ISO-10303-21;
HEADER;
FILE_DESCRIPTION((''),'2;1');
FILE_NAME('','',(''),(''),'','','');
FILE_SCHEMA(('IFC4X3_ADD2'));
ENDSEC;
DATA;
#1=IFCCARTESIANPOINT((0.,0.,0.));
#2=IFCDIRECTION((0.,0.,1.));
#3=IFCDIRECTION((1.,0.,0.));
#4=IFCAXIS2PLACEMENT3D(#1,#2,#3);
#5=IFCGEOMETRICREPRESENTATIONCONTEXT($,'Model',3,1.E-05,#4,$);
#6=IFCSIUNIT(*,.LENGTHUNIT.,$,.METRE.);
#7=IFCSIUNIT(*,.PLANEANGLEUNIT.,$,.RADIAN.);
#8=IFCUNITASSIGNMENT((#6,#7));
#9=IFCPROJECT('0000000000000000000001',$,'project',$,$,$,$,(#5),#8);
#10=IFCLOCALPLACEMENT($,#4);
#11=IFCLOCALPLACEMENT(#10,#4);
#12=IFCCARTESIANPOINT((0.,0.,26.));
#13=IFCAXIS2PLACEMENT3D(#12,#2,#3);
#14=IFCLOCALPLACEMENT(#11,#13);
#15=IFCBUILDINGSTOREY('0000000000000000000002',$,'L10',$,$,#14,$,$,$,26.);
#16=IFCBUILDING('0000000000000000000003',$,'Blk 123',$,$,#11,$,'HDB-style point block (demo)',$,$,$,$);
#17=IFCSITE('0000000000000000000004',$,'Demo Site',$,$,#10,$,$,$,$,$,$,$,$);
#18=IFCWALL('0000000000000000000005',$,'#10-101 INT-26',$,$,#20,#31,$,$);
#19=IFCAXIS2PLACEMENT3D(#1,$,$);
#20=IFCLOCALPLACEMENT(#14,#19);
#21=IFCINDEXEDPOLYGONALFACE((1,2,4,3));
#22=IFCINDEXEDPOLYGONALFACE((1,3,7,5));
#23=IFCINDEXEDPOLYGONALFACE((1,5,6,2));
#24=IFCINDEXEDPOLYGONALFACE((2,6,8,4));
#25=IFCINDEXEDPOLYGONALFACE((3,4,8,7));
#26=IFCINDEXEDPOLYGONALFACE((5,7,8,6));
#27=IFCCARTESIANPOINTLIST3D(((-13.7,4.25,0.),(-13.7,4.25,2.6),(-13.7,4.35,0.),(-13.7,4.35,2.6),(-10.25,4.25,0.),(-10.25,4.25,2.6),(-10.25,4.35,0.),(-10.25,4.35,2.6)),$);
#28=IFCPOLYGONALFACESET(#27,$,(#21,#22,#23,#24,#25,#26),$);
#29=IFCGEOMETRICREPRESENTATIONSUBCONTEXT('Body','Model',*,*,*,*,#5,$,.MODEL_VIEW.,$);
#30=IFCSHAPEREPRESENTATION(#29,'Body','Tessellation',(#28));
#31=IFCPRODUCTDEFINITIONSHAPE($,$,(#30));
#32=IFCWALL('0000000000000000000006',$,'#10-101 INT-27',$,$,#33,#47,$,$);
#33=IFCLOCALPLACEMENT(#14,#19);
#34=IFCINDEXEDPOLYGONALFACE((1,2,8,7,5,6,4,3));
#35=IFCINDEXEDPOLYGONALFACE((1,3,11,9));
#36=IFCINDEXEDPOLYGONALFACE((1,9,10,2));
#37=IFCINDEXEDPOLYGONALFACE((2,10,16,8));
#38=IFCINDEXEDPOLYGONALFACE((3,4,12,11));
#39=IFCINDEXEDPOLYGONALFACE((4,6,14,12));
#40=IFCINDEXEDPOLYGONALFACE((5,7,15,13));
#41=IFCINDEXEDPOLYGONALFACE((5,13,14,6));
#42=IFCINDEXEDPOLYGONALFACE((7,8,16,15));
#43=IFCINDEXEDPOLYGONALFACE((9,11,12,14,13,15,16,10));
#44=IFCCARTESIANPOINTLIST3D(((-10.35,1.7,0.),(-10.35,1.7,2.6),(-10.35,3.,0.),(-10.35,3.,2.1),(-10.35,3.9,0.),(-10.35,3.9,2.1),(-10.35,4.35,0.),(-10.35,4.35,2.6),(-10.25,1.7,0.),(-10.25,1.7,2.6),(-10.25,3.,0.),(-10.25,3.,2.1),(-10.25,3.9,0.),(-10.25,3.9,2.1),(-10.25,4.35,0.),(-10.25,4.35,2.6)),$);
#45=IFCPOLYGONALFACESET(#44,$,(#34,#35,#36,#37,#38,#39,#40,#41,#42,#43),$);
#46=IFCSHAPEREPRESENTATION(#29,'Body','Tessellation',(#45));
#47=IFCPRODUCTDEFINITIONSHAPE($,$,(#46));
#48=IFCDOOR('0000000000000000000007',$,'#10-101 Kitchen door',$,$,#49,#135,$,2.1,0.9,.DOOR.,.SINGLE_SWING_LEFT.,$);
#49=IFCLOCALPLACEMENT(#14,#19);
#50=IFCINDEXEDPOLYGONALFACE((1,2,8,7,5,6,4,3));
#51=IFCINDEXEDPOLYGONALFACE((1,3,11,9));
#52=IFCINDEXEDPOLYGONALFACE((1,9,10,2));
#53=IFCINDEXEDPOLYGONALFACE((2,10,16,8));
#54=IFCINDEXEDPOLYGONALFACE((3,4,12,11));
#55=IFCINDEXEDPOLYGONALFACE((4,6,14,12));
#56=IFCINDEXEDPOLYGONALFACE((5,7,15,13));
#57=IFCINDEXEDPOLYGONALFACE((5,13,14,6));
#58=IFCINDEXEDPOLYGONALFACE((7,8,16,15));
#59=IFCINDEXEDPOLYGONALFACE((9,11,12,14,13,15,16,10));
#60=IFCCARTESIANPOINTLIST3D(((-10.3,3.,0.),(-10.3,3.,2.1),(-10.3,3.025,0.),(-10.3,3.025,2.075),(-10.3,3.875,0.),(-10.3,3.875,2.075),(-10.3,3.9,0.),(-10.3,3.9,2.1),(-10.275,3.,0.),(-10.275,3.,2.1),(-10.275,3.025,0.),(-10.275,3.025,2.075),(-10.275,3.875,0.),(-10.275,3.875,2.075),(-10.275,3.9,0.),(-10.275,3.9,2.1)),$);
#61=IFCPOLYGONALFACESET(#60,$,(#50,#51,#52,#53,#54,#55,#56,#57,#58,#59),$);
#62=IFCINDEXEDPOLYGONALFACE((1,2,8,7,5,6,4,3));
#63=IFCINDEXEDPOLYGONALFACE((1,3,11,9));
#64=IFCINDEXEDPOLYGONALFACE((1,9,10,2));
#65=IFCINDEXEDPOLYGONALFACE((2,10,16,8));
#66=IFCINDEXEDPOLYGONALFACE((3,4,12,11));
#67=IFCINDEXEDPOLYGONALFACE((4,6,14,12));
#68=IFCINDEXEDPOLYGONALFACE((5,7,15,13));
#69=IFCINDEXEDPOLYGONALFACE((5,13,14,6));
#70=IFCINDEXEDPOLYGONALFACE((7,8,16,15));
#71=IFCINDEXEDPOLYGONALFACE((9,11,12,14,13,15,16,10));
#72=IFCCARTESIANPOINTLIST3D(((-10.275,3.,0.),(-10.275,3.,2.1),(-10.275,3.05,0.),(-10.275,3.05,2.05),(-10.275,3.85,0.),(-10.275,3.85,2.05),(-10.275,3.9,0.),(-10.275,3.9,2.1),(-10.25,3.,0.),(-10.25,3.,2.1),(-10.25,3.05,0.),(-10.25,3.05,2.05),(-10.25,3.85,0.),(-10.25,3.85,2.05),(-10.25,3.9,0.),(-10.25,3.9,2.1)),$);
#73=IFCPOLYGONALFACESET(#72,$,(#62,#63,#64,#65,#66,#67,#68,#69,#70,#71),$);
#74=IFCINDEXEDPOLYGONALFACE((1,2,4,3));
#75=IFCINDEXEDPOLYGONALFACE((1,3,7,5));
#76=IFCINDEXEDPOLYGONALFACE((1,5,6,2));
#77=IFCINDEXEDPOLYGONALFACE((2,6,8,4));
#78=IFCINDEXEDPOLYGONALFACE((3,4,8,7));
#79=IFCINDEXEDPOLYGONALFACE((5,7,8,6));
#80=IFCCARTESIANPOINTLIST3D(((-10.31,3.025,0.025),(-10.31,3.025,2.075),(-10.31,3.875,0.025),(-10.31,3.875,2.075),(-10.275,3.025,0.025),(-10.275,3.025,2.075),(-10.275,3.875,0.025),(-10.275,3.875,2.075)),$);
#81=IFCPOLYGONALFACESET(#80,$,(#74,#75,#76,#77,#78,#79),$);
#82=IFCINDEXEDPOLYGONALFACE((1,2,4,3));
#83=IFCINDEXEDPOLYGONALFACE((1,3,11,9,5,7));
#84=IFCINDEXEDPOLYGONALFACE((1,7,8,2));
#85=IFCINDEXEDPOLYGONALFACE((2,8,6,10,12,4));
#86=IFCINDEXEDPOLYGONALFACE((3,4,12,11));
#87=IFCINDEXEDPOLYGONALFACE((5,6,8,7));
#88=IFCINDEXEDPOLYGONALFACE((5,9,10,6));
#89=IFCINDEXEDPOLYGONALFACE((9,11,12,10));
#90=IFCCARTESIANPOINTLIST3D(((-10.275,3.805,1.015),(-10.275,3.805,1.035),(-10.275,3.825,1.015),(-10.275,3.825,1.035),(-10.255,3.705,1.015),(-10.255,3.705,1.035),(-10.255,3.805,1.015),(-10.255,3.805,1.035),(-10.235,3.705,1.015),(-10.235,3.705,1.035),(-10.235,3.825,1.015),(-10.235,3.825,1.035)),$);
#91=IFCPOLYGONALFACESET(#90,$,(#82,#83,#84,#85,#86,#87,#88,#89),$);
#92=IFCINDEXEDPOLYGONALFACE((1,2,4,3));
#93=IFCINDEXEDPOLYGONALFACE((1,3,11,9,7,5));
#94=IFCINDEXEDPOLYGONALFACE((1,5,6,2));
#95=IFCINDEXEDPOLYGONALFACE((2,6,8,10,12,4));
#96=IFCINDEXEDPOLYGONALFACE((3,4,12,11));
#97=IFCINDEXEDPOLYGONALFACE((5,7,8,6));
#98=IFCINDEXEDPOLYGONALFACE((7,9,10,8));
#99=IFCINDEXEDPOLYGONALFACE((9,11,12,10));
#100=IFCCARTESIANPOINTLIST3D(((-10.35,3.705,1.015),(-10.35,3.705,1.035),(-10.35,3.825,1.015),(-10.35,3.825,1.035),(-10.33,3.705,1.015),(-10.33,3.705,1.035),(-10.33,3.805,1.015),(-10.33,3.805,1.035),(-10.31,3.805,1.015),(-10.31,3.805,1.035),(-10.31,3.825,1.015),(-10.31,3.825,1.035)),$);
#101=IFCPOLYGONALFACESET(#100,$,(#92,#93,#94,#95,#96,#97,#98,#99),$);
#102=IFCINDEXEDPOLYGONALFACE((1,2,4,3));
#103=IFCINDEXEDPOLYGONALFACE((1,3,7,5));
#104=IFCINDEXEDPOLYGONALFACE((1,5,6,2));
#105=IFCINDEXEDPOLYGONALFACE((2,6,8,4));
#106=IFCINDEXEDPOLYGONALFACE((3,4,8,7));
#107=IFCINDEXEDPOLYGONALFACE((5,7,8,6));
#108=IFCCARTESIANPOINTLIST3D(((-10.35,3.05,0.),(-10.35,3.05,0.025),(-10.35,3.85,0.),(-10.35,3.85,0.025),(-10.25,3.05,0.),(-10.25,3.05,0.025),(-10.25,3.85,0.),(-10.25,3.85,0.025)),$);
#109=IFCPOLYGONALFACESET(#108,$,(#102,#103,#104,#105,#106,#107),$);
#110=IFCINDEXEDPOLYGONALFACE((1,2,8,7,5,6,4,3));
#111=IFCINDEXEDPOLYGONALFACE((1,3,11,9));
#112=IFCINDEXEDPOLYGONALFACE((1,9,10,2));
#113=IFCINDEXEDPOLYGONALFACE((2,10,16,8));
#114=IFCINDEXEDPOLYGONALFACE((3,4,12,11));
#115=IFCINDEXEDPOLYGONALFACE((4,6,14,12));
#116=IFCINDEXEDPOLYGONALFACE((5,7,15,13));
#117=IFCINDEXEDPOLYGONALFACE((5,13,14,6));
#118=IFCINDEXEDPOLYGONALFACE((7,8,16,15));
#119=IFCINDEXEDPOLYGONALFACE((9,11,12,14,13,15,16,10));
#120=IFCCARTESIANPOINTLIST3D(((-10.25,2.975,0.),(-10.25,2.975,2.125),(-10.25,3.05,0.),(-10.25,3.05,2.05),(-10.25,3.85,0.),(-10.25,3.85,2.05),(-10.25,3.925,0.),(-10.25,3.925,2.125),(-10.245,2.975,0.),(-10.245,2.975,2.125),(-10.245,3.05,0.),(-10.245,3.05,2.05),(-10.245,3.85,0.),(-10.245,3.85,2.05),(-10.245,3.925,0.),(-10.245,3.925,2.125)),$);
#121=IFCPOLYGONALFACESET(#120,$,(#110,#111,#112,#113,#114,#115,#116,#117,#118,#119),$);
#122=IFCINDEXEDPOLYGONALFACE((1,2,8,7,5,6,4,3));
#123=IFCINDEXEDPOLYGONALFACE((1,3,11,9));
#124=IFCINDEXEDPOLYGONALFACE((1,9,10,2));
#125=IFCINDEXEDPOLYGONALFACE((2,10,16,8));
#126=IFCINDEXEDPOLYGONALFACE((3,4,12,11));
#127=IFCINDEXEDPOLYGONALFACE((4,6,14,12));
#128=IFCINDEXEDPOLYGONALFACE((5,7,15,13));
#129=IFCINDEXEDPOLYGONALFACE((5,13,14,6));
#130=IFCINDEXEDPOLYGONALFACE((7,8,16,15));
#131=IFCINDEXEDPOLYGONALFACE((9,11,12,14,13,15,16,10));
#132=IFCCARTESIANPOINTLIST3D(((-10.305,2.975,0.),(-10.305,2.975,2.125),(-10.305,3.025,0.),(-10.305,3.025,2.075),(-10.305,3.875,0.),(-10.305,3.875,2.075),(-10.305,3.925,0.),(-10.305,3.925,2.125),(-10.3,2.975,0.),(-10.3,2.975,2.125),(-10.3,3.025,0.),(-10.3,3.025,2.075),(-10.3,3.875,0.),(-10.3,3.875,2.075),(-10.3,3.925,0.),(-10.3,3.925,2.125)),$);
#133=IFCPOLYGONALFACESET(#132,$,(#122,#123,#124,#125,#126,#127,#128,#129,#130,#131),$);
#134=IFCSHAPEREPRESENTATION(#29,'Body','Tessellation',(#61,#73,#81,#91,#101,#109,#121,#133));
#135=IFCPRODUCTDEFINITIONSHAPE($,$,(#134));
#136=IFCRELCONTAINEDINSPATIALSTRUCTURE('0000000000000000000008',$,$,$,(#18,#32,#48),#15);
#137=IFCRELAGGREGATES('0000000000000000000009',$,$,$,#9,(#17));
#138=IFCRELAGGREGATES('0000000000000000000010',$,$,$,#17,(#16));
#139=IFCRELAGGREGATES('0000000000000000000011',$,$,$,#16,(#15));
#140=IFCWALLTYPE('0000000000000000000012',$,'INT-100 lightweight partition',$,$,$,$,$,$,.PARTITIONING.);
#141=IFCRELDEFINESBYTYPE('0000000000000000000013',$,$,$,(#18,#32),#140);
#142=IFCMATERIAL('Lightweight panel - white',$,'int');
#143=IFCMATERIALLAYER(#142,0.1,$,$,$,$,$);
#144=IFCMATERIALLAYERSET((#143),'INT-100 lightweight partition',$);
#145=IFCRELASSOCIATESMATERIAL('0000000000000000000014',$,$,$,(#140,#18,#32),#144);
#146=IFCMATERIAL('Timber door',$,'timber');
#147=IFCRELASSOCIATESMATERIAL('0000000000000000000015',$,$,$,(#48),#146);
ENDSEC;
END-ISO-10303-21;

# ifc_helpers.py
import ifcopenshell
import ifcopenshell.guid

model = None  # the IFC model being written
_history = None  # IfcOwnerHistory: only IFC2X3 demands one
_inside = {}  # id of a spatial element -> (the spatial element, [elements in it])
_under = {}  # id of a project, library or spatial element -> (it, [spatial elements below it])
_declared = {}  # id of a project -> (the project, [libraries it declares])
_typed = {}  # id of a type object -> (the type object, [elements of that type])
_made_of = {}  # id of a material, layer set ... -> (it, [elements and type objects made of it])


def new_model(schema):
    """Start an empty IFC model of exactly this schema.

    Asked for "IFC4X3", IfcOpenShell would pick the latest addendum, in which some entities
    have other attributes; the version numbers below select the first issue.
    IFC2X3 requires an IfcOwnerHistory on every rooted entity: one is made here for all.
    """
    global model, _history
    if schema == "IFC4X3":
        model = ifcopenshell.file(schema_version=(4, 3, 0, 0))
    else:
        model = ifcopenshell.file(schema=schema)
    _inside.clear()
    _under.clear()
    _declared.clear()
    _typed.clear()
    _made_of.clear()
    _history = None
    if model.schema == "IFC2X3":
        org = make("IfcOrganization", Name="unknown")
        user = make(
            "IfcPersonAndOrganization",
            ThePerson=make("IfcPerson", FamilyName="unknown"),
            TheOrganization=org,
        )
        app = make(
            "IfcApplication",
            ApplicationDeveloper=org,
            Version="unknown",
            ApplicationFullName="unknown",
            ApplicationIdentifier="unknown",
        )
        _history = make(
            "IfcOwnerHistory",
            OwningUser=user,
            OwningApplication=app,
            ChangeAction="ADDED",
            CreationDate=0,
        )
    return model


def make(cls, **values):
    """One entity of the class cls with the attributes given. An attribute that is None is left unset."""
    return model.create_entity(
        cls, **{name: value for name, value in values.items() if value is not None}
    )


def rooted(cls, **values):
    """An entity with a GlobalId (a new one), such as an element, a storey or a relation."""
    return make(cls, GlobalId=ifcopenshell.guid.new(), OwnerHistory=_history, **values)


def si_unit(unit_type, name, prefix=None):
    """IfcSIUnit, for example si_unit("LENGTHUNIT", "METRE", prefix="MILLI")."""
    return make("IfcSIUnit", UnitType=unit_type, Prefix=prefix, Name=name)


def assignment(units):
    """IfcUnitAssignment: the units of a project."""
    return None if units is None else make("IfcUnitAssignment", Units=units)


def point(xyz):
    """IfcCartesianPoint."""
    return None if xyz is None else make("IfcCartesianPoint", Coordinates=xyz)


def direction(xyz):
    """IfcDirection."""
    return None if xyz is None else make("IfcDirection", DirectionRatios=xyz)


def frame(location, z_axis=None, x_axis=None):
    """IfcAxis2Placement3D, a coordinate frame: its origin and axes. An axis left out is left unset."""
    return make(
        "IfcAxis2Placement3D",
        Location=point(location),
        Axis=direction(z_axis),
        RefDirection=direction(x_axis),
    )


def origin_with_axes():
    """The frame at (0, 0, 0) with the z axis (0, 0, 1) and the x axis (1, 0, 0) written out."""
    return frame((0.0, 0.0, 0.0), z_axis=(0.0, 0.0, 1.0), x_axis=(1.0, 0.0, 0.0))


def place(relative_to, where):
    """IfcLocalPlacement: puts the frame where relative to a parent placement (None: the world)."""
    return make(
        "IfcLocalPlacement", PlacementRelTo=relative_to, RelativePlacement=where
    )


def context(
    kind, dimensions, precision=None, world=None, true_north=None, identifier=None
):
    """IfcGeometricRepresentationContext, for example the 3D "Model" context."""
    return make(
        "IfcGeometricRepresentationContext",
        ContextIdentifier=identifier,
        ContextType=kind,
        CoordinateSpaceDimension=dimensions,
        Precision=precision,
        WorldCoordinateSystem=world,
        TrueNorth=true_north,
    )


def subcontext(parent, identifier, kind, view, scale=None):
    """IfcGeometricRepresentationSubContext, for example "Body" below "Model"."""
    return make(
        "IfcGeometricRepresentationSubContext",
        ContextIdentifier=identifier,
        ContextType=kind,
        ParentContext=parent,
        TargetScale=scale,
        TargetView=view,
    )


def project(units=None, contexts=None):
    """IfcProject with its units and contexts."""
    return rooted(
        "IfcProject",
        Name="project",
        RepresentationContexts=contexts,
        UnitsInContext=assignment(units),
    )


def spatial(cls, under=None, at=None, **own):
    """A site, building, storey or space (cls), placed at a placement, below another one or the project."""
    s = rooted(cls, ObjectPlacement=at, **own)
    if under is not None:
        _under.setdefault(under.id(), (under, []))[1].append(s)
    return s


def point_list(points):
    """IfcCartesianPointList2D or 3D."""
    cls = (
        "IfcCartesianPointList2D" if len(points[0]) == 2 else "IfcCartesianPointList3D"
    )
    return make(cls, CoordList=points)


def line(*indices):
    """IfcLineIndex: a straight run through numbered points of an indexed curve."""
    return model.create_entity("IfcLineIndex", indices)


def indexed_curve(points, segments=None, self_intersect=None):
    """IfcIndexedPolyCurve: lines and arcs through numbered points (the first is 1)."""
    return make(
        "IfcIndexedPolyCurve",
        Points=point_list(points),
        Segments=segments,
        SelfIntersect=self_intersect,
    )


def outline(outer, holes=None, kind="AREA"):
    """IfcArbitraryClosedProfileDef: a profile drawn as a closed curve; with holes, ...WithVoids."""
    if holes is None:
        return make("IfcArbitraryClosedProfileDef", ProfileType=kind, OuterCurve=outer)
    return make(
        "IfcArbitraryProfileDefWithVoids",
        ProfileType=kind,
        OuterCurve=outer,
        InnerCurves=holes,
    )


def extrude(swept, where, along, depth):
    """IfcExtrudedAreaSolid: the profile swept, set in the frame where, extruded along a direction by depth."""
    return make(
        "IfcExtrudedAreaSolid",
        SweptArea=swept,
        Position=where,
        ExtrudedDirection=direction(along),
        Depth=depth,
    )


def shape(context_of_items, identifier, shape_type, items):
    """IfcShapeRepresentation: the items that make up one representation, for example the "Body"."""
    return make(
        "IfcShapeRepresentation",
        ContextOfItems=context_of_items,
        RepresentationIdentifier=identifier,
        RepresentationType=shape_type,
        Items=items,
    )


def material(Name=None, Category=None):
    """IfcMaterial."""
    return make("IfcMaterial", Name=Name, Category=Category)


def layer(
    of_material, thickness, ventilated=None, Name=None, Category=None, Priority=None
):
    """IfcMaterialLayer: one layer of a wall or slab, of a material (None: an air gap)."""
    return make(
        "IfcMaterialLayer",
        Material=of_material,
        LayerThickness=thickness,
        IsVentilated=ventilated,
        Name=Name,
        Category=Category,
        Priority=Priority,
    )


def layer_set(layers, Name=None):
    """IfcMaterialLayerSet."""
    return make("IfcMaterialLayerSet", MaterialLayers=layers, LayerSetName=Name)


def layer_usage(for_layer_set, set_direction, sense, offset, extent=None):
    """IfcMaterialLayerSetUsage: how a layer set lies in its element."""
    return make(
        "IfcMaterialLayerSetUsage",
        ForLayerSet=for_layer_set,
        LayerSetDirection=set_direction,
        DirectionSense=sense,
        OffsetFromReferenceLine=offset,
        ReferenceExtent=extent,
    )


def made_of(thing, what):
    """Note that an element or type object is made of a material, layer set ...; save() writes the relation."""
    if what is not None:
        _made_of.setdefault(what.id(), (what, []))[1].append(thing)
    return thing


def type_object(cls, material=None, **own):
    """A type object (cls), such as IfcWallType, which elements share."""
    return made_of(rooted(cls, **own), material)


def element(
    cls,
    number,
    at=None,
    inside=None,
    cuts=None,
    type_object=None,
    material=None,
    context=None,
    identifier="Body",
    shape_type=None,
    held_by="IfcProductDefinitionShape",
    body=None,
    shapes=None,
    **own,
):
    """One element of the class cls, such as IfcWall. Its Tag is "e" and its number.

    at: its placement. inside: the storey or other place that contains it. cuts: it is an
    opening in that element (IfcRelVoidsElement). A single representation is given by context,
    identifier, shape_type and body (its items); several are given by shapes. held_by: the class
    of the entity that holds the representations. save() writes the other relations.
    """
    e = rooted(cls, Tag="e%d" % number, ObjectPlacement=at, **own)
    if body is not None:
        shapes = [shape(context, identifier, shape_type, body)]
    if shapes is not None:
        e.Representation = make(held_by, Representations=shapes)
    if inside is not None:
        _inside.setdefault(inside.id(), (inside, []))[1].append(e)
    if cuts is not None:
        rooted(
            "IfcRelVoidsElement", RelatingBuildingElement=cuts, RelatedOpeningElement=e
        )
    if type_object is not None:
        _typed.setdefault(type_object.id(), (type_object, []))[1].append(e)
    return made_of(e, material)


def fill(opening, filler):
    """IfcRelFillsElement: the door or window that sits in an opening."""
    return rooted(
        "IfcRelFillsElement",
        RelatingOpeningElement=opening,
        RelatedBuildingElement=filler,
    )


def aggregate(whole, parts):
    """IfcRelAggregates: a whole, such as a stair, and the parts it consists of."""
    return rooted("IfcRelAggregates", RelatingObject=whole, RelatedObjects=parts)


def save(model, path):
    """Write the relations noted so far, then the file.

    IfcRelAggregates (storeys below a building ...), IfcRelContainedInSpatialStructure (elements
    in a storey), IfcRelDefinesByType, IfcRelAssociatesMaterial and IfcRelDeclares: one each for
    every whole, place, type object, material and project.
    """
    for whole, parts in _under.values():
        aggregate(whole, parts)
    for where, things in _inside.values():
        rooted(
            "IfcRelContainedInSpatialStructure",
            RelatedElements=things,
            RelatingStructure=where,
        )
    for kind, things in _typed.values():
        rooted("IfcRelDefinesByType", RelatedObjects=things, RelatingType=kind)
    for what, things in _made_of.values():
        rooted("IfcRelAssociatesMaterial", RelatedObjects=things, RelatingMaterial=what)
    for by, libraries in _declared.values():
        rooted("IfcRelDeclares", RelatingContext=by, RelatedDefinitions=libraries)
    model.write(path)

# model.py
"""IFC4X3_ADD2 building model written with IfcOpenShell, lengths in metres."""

from ifc_helpers import new_model, si_unit, frame, origin_with_axes, place, context, subcontext, project, spatial, line, indexed_curve, outline, extrude, material, layer, layer_set, layer_usage, type_object, element, fill, save


model = new_model("IFC4X3_ADD2")

# Units and contexts
model_context = context("Model", 3, precision=1e-05, world=origin_with_axes())
body_context = subcontext(model_context, "Body", "Model", "MODEL_VIEW")
ifc_project = project(units=[si_unit("LENGTHUNIT", "METRE"), si_unit("PLANEANGLEUNIT", "RADIAN")], contexts=[model_context])

# Site, building, storey
site_placement = place(None, origin_with_axes())
site = spatial("IfcSite", under=ifc_project, at=site_placement, Name="Demo Site")
building_placement = place(site_placement, origin_with_axes())
building = spatial("IfcBuilding", under=site, at=building_placement, Name="Blk 123", LongName="HDB-style point block (demo)")
storey_placement = place(building_placement, frame((0.0, 0.0, 26.0), z_axis=(0.0, 0.0, 1.0), x_axis=(1.0, 0.0, 0.0)))
storey = spatial("IfcBuildingStorey", under=building, at=storey_placement, Name="L10", Elevation=26.0)

# Shared definitions
ifc_material_1 = material(Name="Timber door", Category="timber")

# Wall
ifc_material_2 = material(Name="Lightweight panel - white", Category="int")
ifc_layer_1 = layer(ifc_material_2, 0.1)
ifc_layer_set_1 = layer_set([ifc_layer_1], Name="INT-100 lightweight partition")
ifc_layer_usage_1 = layer_usage(ifc_layer_set_1, "AXIS2", "POSITIVE", -0.05)
wall_type_1 = type_object("IfcWallType", Name="INT-100 lightweight partition", PredefinedType="PARTITIONING", material=ifc_layer_set_1)
wall_1_placement = place(storey_placement, frame((-10.25, 4.3, 0.0), z_axis=(0.0, 0.0, 1.0), x_axis=(-1.0, 0.0, 0.0)))
element("IfcWall", 1, at=wall_1_placement, inside=storey, type_object=wall_type_1, material=ifc_layer_usage_1, Name="#10-101 INT-26", context=body_context, shape_type="SweptSolid", body=[
    extrude(outline(indexed_curve([(0.0, 0.0), (0.0, 0.1), (3.45, 0.1), (3.45, 0.0), (0.0, 0.0)], self_intersect=False)), frame((0.0, -0.05, 0.0), z_axis=(0.0, 0.0, 1.0), x_axis=(1.0, 0.0, 0.0)), (0.0, 0.0, 1.0), 2.6),
])

# Wall, opening, door
wall_2_placement = place(storey_placement, frame((-10.3, 1.7, 0.0), z_axis=(0.0, 0.0, 1.0), x_axis=(0.0, 1.0, 0.0)))
wall_2 = element("IfcWall", 2, at=wall_2_placement, inside=storey, type_object=wall_type_1, material=ifc_layer_usage_1, Name="#10-101 INT-27", context=body_context, shape_type="SweptSolid", body=[
    extrude(outline(indexed_curve([(0.0, 0.0), (0.0, 0.1), (2.65, 0.1), (2.65, 0.0), (0.0, 0.0)], self_intersect=False)), frame((0.0, -0.05, 0.0), z_axis=(0.0, 0.0, 1.0), x_axis=(1.0, 0.0, 0.0)), (0.0, 0.0, 1.0), 2.6),
])
opening_1_placement = place(wall_2_placement, frame((1.3, -0.15, 0.0), z_axis=(0.0, 0.0, 1.0), x_axis=(1.0, 0.0, 0.0)))
opening_1 = element("IfcOpeningElement", 3, at=opening_1_placement, cuts=wall_2, context=body_context, shape_type="SweptSolid", body=[
    extrude(outline(indexed_curve([(0.0, 0.0), (0.0, 0.3), (0.9, 0.3), (0.9, 0.0), (0.0, 0.0)], self_intersect=False)), origin_with_axes(), (0.0, 0.0, 1.0), 2.1),
])
door_1_placement = place(opening_1_placement, frame((0.0, 0.1, 0.0), z_axis=(0.0, 0.0, 1.0), x_axis=(1.0, 0.0, 0.0)))
door_1 = element("IfcDoor", 4, at=door_1_placement, inside=storey, material=ifc_material_1, Name="#10-101 Kitchen door", OperationType="SINGLE_SWING_LEFT", OverallHeight=2.1, OverallWidth=0.9, PredefinedType="DOOR", context=body_context, shape_type="SweptSolid", body=[
    extrude(outline(indexed_curve([(0.0, 0.0), (0.0, 2.1), (0.9, 2.1), (0.9, 0.0), (0.875, 0.0), (0.875, 2.075), (0.025, 2.075), (0.025, 0.0)], segments=[line(1, 2, 3, 4, 5, 6, 7, 8, 1)])), frame((0.0, 0.025, 0.0), z_axis=(0.0, -1.0, 0.0), x_axis=(1.0, 0.0, 0.0)), (0.0, 0.0, -1.0), 0.025),
    extrude(outline(indexed_curve([(0.0, 0.0), (0.0, 2.1), (0.9, 2.1), (0.9, 0.0), (0.85, 0.0), (0.85, 2.05), (0.05, 2.05), (0.05, 0.0)], segments=[line(1, 2, 3, 4, 5, 6, 7, 8, 1)])), frame((0.0, 0.0, 0.0), z_axis=(0.0, -1.0, 0.0), x_axis=(1.0, 0.0, 0.0)), (0.0, 0.0, -1.0), 0.025),
    extrude(outline(indexed_curve([(0.0, 0.0), (0.85, 0.0), (0.85, 0.035), (0.0, 0.035)], segments=[line(1, 2, 3, 4, 1)])), frame((0.025, 0.025, 0.025), z_axis=(0.0, 0.0, 1.0), x_axis=(1.0, 0.0, 0.0)), (0.0, 0.0, 1.0), 2.05),
    extrude(outline(indexed_curve([(0.0, 0.0), (0.0, -0.04), (-0.12, -0.04), (-0.12, -0.02), (-0.02, -0.02), (-0.02, 0.0)], segments=[line(1, 2, 3, 4, 5, 6, 1)])), frame((0.825, 0.025, 1.015), z_axis=(0.0, 0.0, 1.0), x_axis=(1.0, 0.0, 0.0)), (0.0, 0.0, 1.0), 0.02),
    extrude(outline(indexed_curve([(0.0, 0.0), (0.0, 0.04), (-0.12, 0.04), (-0.12, 0.02), (-0.02, 0.02), (-0.02, 0.0)], segments=[line(1, 2, 3, 4, 5, 6, 1)])), frame((0.825, 0.06, 1.015), z_axis=(0.0, 0.0, 1.0), x_axis=(1.0, 0.0, 0.0)), (0.0, 0.0, 1.0), 0.02),
    extrude(outline(indexed_curve([(0.0, 0.0), (0.8, 0.0), (0.8, 0.1), (0.0, 0.1)], segments=[line(1, 2, 3, 4, 1)])), frame((0.05, 0.0, 0.0), z_axis=(0.0, 0.0, 1.0), x_axis=(1.0, 0.0, 0.0)), (0.0, 0.0, 1.0), 0.025),
    extrude(outline(indexed_curve([(0.0, 0.0), (0.0, 2.125), (0.95, 2.125), (0.95, 0.0), (0.875, 0.0), (0.875, 2.05), (0.075, 2.05), (0.075, 0.0)], segments=[line(1, 2, 3, 4, 5, 6, 7, 8, 1)])), frame((-0.025, -0.005, 0.0), z_axis=(0.0, -1.0, 0.0), x_axis=(1.0, 0.0, 0.0)), (0.0, 0.0, -1.0), 0.005),
    extrude(outline(indexed_curve([(0.0, 0.0), (0.0, 2.125), (0.95, 2.125), (0.95, 0.0), (0.9, 0.0), (0.9, 2.075), (0.05, 2.075), (0.05, 0.0)], segments=[line(1, 2, 3, 4, 5, 6, 7, 8, 1)])), frame((-0.025, 0.05, 0.0), z_axis=(0.0, -1.0, 0.0), x_axis=(1.0, 0.0, 0.0)), (0.0, 0.0, -1.0), 0.005),
])
fill(opening_1, door_1)

save(model, "model.ifc")
